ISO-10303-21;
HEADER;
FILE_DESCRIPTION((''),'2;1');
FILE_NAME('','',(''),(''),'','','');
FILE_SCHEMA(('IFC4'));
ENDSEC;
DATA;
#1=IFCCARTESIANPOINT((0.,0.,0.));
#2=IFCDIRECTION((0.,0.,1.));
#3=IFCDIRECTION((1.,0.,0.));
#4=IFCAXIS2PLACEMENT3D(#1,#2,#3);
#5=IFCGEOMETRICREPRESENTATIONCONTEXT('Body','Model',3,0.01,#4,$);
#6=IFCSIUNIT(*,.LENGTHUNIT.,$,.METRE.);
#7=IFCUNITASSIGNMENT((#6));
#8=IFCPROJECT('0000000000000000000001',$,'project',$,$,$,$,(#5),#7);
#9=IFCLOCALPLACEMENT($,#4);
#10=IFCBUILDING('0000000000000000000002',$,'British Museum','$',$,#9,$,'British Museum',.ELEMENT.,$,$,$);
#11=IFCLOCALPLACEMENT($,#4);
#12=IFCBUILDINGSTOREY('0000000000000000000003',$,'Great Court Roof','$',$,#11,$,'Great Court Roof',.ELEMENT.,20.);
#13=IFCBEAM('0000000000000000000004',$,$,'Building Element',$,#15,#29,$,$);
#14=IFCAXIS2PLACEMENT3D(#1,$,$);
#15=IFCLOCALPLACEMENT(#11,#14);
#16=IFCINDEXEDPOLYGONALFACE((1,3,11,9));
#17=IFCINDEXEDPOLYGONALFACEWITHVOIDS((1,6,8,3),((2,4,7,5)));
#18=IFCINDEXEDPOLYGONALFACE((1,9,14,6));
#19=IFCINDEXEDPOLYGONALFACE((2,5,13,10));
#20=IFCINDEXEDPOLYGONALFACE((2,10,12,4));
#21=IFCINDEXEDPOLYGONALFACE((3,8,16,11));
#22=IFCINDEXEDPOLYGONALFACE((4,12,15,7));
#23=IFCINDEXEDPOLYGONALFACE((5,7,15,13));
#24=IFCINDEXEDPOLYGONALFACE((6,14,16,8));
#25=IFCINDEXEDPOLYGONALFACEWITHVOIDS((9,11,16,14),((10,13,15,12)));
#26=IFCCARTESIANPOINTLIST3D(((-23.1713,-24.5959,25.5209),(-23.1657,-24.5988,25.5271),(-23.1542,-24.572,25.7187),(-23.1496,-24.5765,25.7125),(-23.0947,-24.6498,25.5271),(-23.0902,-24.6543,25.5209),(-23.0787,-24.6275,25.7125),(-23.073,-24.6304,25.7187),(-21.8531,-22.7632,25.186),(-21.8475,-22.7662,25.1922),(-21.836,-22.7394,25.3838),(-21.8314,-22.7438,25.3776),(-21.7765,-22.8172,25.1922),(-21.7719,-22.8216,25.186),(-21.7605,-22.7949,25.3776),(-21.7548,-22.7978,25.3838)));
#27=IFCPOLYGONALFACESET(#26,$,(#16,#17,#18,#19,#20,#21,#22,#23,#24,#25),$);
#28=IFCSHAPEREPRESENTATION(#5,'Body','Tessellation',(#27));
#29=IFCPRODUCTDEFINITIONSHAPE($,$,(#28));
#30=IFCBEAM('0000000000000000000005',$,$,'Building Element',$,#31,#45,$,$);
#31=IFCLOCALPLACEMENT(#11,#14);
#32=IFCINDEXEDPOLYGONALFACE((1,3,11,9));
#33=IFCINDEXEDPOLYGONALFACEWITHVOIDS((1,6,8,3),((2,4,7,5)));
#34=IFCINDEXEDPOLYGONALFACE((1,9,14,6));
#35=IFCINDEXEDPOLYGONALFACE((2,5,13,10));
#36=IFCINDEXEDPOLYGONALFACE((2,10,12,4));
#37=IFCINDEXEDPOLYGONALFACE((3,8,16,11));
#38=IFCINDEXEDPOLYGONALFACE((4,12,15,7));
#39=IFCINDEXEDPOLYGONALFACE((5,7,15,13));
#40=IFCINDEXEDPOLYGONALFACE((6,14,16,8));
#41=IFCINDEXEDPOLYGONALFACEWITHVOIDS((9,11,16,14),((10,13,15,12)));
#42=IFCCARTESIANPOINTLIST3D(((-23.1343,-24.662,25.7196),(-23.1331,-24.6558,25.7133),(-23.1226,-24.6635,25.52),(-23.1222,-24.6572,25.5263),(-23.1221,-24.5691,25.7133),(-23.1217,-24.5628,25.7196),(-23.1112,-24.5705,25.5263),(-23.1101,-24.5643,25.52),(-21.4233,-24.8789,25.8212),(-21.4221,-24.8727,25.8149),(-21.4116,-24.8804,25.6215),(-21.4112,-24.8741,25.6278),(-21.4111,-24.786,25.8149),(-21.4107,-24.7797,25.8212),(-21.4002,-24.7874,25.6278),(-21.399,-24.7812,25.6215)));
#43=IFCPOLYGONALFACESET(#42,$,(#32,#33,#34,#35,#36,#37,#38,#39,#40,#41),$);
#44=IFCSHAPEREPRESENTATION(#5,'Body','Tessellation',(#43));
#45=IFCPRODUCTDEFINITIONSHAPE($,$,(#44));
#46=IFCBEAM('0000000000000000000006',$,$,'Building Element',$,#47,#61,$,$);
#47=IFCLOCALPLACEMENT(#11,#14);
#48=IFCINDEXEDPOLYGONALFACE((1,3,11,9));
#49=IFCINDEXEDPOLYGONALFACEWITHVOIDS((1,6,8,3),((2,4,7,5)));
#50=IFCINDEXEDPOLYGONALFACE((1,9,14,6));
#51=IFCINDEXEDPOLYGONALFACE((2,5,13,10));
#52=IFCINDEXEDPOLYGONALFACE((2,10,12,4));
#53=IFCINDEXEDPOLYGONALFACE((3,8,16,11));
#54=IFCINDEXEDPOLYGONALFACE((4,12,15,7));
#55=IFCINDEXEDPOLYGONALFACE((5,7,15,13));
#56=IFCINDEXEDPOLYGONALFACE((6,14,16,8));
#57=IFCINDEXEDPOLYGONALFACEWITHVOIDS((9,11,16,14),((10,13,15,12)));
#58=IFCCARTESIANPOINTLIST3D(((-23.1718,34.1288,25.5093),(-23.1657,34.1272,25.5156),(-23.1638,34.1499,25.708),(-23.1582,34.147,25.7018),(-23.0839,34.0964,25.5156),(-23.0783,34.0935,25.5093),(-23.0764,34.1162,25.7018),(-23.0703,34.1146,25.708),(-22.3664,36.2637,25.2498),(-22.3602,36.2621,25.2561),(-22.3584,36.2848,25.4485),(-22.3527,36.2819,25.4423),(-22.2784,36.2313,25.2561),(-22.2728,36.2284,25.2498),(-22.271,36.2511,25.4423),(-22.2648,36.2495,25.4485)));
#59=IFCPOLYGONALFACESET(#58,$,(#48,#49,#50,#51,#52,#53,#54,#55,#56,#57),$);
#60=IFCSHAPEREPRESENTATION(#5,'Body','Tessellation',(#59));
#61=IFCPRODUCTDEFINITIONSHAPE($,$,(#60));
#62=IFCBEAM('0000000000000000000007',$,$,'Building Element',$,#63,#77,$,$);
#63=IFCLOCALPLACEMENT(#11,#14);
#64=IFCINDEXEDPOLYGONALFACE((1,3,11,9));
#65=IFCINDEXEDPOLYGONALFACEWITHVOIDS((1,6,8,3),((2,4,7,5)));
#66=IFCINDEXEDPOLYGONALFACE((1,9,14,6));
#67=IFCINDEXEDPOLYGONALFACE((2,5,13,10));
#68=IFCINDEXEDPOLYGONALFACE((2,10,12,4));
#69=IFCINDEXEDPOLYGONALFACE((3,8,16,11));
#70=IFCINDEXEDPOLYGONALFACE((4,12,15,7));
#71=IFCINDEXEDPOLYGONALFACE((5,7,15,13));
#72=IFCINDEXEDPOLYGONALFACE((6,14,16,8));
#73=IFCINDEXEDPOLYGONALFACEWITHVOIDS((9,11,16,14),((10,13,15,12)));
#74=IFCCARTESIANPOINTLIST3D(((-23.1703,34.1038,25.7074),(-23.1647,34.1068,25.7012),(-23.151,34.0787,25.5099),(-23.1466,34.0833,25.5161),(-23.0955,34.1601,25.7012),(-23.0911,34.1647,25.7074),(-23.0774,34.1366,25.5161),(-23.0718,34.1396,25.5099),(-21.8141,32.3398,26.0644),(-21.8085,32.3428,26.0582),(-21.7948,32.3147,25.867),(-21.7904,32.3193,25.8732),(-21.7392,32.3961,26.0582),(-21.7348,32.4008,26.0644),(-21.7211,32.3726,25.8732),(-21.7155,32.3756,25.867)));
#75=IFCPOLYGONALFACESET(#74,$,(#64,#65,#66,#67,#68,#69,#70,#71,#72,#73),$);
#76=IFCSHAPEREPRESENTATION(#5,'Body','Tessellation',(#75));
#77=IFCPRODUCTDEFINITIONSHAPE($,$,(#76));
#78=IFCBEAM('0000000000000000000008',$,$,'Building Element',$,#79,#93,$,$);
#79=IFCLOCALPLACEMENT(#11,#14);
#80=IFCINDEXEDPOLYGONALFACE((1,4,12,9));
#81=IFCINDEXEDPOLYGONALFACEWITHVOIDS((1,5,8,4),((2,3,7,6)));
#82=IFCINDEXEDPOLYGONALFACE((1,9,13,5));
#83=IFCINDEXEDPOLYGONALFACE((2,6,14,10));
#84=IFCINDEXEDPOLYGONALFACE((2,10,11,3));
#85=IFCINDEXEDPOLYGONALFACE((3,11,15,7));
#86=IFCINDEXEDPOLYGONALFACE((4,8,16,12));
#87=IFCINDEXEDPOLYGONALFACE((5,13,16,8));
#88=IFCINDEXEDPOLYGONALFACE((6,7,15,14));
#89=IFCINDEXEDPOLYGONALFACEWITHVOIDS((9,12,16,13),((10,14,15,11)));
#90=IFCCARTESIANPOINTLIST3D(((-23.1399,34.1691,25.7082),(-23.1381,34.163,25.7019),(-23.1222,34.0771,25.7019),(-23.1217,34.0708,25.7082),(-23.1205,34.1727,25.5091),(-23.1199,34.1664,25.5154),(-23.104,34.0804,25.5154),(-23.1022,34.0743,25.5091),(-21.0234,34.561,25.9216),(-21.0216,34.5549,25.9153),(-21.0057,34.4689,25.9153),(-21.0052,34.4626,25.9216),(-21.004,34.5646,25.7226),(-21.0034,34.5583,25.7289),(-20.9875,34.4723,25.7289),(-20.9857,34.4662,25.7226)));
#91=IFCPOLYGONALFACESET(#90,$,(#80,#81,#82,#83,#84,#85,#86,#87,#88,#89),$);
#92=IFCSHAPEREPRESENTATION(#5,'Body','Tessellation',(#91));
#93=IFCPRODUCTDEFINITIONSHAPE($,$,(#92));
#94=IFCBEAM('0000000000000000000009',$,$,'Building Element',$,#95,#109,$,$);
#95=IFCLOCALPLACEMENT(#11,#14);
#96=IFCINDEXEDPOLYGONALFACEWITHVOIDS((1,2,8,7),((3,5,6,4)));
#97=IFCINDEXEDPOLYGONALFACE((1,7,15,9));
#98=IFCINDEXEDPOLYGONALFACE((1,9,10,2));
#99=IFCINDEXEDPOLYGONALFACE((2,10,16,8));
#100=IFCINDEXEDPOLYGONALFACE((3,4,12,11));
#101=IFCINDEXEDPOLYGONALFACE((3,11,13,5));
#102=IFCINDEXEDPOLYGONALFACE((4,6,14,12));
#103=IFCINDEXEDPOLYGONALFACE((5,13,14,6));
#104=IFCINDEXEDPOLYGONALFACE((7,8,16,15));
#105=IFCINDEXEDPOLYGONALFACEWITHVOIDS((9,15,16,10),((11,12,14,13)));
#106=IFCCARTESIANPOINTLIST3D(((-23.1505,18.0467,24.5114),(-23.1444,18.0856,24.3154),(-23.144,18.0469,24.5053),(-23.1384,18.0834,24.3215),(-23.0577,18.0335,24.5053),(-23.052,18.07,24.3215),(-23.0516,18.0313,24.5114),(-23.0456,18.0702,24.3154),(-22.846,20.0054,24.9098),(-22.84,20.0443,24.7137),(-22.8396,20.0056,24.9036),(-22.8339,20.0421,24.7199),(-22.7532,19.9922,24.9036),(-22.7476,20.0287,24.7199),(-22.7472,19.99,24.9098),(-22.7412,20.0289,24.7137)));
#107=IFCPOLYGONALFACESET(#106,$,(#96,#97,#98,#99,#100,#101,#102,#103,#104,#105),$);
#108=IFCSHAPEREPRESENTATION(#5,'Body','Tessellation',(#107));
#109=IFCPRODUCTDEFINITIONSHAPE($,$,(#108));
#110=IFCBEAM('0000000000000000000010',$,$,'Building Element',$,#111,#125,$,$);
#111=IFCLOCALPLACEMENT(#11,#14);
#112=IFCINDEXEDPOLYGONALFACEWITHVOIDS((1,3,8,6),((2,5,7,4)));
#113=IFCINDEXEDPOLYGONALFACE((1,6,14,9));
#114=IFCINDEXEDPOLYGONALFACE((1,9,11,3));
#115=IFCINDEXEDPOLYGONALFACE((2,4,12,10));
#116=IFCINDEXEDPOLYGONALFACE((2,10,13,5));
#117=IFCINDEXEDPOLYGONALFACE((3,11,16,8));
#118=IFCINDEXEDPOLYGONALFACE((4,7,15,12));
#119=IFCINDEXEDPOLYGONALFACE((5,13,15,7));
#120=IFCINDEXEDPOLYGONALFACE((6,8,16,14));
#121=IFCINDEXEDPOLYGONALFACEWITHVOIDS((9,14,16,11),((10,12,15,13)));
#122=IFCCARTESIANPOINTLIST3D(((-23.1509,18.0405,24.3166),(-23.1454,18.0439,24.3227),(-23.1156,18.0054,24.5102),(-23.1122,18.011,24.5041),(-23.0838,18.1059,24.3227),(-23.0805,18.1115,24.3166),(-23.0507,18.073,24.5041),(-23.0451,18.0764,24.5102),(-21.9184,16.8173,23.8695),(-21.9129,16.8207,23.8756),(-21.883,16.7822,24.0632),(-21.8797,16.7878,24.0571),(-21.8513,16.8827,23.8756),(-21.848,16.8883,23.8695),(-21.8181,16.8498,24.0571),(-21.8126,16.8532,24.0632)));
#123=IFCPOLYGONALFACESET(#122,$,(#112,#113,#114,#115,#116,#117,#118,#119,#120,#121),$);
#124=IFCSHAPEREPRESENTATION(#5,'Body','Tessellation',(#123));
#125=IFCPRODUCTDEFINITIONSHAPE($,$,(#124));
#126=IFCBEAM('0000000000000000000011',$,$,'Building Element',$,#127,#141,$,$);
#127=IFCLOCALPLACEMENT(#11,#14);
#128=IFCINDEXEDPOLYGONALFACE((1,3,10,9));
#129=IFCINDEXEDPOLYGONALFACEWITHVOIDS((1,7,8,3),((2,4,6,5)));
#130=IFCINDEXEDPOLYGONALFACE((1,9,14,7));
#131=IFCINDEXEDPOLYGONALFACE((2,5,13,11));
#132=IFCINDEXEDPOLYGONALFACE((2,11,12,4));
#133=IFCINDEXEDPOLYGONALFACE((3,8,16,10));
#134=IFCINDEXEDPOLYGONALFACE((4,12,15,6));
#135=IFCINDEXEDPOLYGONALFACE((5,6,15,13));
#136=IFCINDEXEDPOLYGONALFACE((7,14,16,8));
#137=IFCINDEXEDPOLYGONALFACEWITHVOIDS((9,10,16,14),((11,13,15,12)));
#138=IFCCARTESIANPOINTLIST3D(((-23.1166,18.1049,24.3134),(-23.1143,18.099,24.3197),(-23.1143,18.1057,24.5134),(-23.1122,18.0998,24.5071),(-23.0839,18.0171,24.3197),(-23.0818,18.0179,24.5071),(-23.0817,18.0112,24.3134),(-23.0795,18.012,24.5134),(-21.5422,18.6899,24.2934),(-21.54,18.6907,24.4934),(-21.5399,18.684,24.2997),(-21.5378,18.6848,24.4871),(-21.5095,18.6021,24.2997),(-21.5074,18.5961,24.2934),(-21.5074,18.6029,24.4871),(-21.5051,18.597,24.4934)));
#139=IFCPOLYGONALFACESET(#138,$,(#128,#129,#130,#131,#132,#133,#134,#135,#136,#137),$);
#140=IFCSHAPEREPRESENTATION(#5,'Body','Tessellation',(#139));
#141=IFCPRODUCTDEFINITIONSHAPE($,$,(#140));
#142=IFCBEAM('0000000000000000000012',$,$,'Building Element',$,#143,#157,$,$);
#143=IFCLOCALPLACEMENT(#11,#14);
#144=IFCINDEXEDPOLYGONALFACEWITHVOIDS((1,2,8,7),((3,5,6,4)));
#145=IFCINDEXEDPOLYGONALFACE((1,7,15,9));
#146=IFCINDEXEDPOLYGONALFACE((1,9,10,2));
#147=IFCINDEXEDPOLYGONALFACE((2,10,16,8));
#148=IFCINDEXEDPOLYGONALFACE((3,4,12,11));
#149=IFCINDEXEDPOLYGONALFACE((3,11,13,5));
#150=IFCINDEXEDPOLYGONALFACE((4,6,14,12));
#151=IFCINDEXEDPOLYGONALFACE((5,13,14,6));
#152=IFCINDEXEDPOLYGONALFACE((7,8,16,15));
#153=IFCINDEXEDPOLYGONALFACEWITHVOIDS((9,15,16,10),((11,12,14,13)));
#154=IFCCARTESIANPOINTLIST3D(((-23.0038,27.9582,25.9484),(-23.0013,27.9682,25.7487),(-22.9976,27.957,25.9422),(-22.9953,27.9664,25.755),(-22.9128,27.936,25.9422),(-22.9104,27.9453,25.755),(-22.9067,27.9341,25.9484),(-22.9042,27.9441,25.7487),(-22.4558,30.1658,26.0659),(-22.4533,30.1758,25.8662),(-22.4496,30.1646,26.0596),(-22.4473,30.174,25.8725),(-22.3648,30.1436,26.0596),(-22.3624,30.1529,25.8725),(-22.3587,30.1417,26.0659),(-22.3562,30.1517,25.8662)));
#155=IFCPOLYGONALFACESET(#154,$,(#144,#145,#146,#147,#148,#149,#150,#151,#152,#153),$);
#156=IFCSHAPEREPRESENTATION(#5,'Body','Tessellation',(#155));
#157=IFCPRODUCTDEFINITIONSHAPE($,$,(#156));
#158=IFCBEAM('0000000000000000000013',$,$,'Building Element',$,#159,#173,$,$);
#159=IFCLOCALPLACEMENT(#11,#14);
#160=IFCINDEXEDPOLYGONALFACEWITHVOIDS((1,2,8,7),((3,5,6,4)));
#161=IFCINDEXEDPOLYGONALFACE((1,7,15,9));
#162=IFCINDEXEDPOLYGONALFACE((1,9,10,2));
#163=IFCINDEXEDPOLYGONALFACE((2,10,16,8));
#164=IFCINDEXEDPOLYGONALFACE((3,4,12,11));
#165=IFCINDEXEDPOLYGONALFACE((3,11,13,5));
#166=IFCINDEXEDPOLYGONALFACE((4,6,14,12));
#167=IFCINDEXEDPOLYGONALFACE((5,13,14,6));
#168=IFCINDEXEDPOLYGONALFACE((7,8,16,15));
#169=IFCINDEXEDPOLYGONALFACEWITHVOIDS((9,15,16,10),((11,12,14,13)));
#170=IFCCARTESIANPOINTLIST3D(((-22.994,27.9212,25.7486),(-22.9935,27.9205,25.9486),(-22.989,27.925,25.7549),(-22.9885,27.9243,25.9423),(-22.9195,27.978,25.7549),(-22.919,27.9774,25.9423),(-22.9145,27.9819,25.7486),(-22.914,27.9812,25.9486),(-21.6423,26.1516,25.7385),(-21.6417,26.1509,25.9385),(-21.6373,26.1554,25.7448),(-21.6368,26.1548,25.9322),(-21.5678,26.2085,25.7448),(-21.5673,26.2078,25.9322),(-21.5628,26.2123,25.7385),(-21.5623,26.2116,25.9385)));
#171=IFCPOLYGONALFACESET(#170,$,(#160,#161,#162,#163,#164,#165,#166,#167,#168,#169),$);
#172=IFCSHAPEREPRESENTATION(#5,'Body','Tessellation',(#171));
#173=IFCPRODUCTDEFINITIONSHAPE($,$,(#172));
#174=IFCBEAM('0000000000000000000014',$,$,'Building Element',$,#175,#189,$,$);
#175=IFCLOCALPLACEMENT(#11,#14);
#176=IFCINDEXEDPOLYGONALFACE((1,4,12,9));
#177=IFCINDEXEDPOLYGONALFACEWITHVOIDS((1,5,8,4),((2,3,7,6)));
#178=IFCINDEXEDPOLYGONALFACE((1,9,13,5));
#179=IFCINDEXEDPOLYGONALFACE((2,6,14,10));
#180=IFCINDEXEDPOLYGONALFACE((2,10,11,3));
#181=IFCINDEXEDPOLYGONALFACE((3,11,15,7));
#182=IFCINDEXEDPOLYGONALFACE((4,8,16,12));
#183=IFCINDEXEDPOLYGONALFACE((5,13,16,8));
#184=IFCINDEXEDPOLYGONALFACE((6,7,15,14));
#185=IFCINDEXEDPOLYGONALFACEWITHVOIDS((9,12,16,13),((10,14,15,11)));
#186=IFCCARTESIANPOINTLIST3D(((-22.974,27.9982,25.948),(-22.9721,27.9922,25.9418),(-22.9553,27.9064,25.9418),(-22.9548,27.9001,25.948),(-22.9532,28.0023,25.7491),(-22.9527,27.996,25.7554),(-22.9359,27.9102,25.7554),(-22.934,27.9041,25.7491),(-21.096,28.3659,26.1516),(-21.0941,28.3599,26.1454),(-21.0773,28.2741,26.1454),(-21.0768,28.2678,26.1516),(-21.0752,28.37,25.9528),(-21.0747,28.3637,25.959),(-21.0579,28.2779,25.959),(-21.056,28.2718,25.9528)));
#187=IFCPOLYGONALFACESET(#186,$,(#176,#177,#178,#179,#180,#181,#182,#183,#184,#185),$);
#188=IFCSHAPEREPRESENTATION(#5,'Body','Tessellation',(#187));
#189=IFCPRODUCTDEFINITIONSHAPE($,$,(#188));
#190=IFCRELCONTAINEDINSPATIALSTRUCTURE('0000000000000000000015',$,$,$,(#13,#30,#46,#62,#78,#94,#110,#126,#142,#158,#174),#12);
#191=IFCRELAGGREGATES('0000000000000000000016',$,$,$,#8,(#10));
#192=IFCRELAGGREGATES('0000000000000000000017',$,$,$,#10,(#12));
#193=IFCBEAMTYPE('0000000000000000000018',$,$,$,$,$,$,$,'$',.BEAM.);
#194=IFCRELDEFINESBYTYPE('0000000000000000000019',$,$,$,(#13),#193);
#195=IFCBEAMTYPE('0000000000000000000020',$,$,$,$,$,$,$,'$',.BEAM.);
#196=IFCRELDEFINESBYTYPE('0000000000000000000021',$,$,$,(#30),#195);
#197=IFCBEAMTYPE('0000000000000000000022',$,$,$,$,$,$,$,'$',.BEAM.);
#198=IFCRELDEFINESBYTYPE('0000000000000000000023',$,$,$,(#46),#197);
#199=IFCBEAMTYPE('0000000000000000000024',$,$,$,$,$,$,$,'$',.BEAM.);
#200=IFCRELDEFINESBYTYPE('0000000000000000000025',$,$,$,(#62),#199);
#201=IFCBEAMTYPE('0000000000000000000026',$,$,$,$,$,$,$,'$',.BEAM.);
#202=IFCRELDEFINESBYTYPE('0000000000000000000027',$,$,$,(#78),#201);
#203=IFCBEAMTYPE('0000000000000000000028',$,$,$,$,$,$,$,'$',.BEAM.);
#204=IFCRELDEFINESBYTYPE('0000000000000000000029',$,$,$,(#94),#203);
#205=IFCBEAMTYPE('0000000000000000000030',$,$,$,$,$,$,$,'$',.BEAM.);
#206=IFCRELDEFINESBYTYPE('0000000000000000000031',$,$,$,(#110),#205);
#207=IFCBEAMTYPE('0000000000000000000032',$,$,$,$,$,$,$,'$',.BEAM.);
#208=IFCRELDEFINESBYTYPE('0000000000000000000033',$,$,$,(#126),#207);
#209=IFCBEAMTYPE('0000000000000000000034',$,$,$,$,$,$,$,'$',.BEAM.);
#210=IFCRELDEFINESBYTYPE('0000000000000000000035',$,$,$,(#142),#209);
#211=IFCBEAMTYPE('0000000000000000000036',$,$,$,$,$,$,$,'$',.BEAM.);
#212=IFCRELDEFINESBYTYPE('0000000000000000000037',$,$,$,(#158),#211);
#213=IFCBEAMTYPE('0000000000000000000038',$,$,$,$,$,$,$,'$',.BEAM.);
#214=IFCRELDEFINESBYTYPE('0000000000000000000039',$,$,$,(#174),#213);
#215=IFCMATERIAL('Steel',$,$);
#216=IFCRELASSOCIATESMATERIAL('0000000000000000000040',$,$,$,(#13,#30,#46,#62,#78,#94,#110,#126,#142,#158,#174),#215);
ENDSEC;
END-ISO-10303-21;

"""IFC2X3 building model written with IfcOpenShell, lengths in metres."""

from ifc_helpers import new_model, si_unit, frame, origin_with_axes, origin_2d, place, context, project, spatial, hollow_rectangle, extrude, material, type_object, element, save


model = new_model("IFC2X3")

# Units and contexts
model_context = context("Model", 3, precision=0.01, world=origin_with_axes(), identifier="Body")
ifc_project = project(units=[si_unit("LENGTHUNIT", "METRE")], contexts=[model_context])

# Building, storey
building_placement = place(None, origin_with_axes())
building = spatial("IfcBuilding", under=ifc_project, at=building_placement, Name="British Museum", Description="$", LongName="British Museum", CompositionType="ELEMENT")
storey_placement = place(None, origin_with_axes())
storey = spatial("IfcBuildingStorey", under=building, at=storey_placement, Name="Great Court Roof", Description="$", LongName="Great Court Roof", CompositionType="ELEMENT", Elevation=20.0)

# Beams
ifc_material = material(Name="Steel")
beam_type_1 = type_object("IfcBeamType", ElementType="$", PredefinedType="BEAM")
beam_1_placement = place(None, origin_with_axes())
element("IfcBeam", 1, at=beam_1_placement, inside=storey, type_object=beam_type_1, material=ifc_material, Description="Building Element", context=model_context, shape_type="SweptSolid", body=[
    extrude(hollow_rectangle(XDim=0.1, YDim=0.2, WallThickness=0.0063, InnerFilletRadius=-0.0063, OuterFilletRadius=0.0, at=origin_2d()), frame((-23.1222, -24.6132, 25.6198), z_axis=(0.577613, 0.803013, -0.14674), x_axis=(-0.811801, 0.583934, 0.0)), (0.0, 0.0, 1.0), 2.2822),
])
beam_type_2 = type_object("IfcBeamType", ElementType="$", PredefinedType="BEAM")
beam_2_placement = place(None, origin_with_axes())
element("IfcBeam", 2, at=beam_2_placement, inside=storey, type_object=beam_type_2, material=ifc_material, Description="Building Element", context=model_context, shape_type="SweptSolid", body=[
    extrude(hollow_rectangle(XDim=0.1, YDim=0.2, WallThickness=0.0063, InnerFilletRadius=-0.0063, OuterFilletRadius=0.0, at=origin_2d()), frame((-23.1222, -24.6132, 25.6198), z_axis=(0.990343, -0.125555, 0.058791), x_axis=(0.125773, 0.992059, 0.0)), (0.0, 0.0, 1.0), 1.7277),
])
beam_type_3 = type_object("IfcBeamType", ElementType="$", PredefinedType="BEAM")
beam_3_placement = place(None, origin_with_axes())
element("IfcBeam", 3, at=beam_3_placement, inside=storey, type_object=beam_type_3, material=ifc_material, Description="Building Element", context=model_context, shape_type="SweptSolid", body=[
    extrude(hollow_rectangle(XDim=0.1, YDim=0.2, WallThickness=0.0063, InnerFilletRadius=-0.0063, OuterFilletRadius=0.0, at=origin_2d()), frame((-23.1211, 34.1217, 25.6087), z_axis=(0.350736, 0.929633, -0.112991), x_axis=(-0.935625, 0.352997, 0.0)), (0.0, 0.0, 1.0), 2.2965),
])
beam_type_4 = type_object("IfcBeamType", ElementType="$", PredefinedType="BEAM")
beam_4_placement = place(None, origin_with_axes())
element("IfcBeam", 4, at=beam_4_placement, inside=storey, type_object=beam_type_4, material=ifc_material, Description="Building Element", context=model_context, shape_type="SweptSolid", body=[
    extrude(hollow_rectangle(XDim=0.1, YDim=0.2, WallThickness=0.0063, InnerFilletRadius=-0.0063, OuterFilletRadius=0.0, at=origin_2d()), frame((-23.1211, 34.1217, 25.6087), z_axis=(0.601831, -0.782749, 0.158437), x_axis=(0.792763, 0.60953, 0.0)), (0.0, 0.0, 1.0), 2.2536),
])
beam_type_5 = type_object("IfcBeamType", ElementType="$", PredefinedType="BEAM")
beam_5_placement = place(None, origin_with_axes())
element("IfcBeam", 5, at=beam_5_placement, inside=storey, type_object=beam_type_5, material=ifc_material, Description="Building Element", context=model_context, shape_type="SweptSolid", body=[
    extrude(hollow_rectangle(XDim=0.1, YDim=0.2, WallThickness=0.0063, InnerFilletRadius=-0.0063, OuterFilletRadius=0.0, at=origin_2d()), frame((-23.1211, 34.1217, 25.6087), z_axis=(0.978487, 0.181177, 0.098681), x_axis=(-0.182066, 0.983286, 0.0)), (0.0, 0.0, 1.0), 2.163),
])
beam_type_6 = type_object("IfcBeamType", ElementType="$", PredefinedType="BEAM")
beam_6_placement = place(None, origin_with_axes())
element("IfcBeam", 6, at=beam_6_placement, inside=storey, type_object=beam_type_6, material=ifc_material, Description="Building Element", context=model_context, shape_type="SweptSolid", body=[
    extrude(hollow_rectangle(XDim=0.1, YDim=0.2, WallThickness=0.0063, InnerFilletRadius=-0.0063, OuterFilletRadius=0.0, at=origin_2d()), frame((-23.098, 18.0584, 24.4134), z_axis=(0.150576, 0.96877, 0.197005), x_axis=(-0.988135, 0.153586, 0.0)), (0.0, 0.0, 1.0), 2.0219),
])
beam_type_7 = type_object("IfcBeamType", ElementType="$", PredefinedType="BEAM")
beam_7_placement = place(None, origin_with_axes())
element("IfcBeam", 7, at=beam_7_placement, inside=storey, type_object=beam_type_7, material=ifc_material, Description="Building Element", context=model_context, shape_type="SweptSolid", body=[
    extrude(hollow_rectangle(XDim=0.1, YDim=0.2, WallThickness=0.0063, InnerFilletRadius=-0.0063, OuterFilletRadius=0.0, at=origin_2d()), frame((-23.098, 18.0584, 24.4134), z_axis=(0.687364, -0.682172, -0.249341), x_axis=(0.704421, 0.709782, 0.0)), (0.0, 0.0, 1.0), 1.7931),
])
beam_type_8 = type_object("IfcBeamType", ElementType="$", PredefinedType="BEAM")
beam_8_placement = place(None, origin_with_axes())
element("IfcBeam", 8, at=beam_8_placement, inside=storey, type_object=beam_type_8, material=ifc_material, Description="Building Element", context=model_context, shape_type="SweptSolid", body=[
    extrude(hollow_rectangle(XDim=0.1, YDim=0.2, WallThickness=0.0063, InnerFilletRadius=-0.0063, OuterFilletRadius=0.0, at=origin_2d()), frame((-23.098, 18.0584, 24.4134), z_axis=(0.937314, 0.348283, -0.011915), x_axis=(-0.348308, 0.93738, 0.0)), (0.0, 0.0, 1.0), 1.6796),
])
beam_type_9 = type_object("IfcBeamType", ElementType="$", PredefinedType="BEAM")
beam_9_placement = place(None, origin_with_axes())
element("IfcBeam", 9, at=beam_9_placement, inside=storey, type_object=beam_type_9, material=ifc_material, Description="Building Element", context=model_context, shape_type="SweptSolid", body=[
    extrude(hollow_rectangle(XDim=0.1, YDim=0.2, WallThickness=0.0063, InnerFilletRadius=-0.0063, OuterFilletRadius=0.0, at=origin_2d()), frame((-22.954, 27.9512, 25.8486), z_axis=(0.240597, 0.969253, 0.051584), x_axis=(-0.970546, 0.240918, 0.0)), (0.0, 0.0, 1.0), 2.2776),
])
beam_type_10 = type_object("IfcBeamType", ElementType="$", PredefinedType="BEAM")
beam_10_placement = place(None, origin_with_axes())
element("IfcBeam", 10, at=beam_10_placement, inside=storey, type_object=beam_type_10, material=ifc_material, Description="Building Element", context=model_context, shape_type="SweptSolid", body=[
    extrude(hollow_rectangle(XDim=0.1, YDim=0.2, WallThickness=0.0063, InnerFilletRadius=-0.0063, OuterFilletRadius=0.0, at=origin_2d()), frame((-22.954, 27.9512, 25.8486), z_axis=(0.607027, -0.794668, -0.004545), x_axis=(0.794676, 0.607034, 0.0)), (0.0, 0.0, 1.0), 2.2268),
])
beam_type_11 = type_object("IfcBeamType", ElementType="$", PredefinedType="BEAM")
beam_11_placement = place(None, origin_with_axes())
element("IfcBeam", 11, at=beam_11_placement, inside=storey, type_object=beam_type_11, material=ifc_material, Description="Building Element", context=model_context, shape_type="SweptSolid", body=[
    extrude(hollow_rectangle(XDim=0.1, YDim=0.2, WallThickness=0.0063, InnerFilletRadius=-0.0063, OuterFilletRadius=0.0, at=origin_2d()), frame((-22.954, 27.9512, 25.8486), z_axis=(0.975858, 0.191067, 0.105805), x_axis=(-0.192146, 0.981366, 0.0)), (0.0, 0.0, 1.0), 1.9245),
])

save(model, "model.ifc")
